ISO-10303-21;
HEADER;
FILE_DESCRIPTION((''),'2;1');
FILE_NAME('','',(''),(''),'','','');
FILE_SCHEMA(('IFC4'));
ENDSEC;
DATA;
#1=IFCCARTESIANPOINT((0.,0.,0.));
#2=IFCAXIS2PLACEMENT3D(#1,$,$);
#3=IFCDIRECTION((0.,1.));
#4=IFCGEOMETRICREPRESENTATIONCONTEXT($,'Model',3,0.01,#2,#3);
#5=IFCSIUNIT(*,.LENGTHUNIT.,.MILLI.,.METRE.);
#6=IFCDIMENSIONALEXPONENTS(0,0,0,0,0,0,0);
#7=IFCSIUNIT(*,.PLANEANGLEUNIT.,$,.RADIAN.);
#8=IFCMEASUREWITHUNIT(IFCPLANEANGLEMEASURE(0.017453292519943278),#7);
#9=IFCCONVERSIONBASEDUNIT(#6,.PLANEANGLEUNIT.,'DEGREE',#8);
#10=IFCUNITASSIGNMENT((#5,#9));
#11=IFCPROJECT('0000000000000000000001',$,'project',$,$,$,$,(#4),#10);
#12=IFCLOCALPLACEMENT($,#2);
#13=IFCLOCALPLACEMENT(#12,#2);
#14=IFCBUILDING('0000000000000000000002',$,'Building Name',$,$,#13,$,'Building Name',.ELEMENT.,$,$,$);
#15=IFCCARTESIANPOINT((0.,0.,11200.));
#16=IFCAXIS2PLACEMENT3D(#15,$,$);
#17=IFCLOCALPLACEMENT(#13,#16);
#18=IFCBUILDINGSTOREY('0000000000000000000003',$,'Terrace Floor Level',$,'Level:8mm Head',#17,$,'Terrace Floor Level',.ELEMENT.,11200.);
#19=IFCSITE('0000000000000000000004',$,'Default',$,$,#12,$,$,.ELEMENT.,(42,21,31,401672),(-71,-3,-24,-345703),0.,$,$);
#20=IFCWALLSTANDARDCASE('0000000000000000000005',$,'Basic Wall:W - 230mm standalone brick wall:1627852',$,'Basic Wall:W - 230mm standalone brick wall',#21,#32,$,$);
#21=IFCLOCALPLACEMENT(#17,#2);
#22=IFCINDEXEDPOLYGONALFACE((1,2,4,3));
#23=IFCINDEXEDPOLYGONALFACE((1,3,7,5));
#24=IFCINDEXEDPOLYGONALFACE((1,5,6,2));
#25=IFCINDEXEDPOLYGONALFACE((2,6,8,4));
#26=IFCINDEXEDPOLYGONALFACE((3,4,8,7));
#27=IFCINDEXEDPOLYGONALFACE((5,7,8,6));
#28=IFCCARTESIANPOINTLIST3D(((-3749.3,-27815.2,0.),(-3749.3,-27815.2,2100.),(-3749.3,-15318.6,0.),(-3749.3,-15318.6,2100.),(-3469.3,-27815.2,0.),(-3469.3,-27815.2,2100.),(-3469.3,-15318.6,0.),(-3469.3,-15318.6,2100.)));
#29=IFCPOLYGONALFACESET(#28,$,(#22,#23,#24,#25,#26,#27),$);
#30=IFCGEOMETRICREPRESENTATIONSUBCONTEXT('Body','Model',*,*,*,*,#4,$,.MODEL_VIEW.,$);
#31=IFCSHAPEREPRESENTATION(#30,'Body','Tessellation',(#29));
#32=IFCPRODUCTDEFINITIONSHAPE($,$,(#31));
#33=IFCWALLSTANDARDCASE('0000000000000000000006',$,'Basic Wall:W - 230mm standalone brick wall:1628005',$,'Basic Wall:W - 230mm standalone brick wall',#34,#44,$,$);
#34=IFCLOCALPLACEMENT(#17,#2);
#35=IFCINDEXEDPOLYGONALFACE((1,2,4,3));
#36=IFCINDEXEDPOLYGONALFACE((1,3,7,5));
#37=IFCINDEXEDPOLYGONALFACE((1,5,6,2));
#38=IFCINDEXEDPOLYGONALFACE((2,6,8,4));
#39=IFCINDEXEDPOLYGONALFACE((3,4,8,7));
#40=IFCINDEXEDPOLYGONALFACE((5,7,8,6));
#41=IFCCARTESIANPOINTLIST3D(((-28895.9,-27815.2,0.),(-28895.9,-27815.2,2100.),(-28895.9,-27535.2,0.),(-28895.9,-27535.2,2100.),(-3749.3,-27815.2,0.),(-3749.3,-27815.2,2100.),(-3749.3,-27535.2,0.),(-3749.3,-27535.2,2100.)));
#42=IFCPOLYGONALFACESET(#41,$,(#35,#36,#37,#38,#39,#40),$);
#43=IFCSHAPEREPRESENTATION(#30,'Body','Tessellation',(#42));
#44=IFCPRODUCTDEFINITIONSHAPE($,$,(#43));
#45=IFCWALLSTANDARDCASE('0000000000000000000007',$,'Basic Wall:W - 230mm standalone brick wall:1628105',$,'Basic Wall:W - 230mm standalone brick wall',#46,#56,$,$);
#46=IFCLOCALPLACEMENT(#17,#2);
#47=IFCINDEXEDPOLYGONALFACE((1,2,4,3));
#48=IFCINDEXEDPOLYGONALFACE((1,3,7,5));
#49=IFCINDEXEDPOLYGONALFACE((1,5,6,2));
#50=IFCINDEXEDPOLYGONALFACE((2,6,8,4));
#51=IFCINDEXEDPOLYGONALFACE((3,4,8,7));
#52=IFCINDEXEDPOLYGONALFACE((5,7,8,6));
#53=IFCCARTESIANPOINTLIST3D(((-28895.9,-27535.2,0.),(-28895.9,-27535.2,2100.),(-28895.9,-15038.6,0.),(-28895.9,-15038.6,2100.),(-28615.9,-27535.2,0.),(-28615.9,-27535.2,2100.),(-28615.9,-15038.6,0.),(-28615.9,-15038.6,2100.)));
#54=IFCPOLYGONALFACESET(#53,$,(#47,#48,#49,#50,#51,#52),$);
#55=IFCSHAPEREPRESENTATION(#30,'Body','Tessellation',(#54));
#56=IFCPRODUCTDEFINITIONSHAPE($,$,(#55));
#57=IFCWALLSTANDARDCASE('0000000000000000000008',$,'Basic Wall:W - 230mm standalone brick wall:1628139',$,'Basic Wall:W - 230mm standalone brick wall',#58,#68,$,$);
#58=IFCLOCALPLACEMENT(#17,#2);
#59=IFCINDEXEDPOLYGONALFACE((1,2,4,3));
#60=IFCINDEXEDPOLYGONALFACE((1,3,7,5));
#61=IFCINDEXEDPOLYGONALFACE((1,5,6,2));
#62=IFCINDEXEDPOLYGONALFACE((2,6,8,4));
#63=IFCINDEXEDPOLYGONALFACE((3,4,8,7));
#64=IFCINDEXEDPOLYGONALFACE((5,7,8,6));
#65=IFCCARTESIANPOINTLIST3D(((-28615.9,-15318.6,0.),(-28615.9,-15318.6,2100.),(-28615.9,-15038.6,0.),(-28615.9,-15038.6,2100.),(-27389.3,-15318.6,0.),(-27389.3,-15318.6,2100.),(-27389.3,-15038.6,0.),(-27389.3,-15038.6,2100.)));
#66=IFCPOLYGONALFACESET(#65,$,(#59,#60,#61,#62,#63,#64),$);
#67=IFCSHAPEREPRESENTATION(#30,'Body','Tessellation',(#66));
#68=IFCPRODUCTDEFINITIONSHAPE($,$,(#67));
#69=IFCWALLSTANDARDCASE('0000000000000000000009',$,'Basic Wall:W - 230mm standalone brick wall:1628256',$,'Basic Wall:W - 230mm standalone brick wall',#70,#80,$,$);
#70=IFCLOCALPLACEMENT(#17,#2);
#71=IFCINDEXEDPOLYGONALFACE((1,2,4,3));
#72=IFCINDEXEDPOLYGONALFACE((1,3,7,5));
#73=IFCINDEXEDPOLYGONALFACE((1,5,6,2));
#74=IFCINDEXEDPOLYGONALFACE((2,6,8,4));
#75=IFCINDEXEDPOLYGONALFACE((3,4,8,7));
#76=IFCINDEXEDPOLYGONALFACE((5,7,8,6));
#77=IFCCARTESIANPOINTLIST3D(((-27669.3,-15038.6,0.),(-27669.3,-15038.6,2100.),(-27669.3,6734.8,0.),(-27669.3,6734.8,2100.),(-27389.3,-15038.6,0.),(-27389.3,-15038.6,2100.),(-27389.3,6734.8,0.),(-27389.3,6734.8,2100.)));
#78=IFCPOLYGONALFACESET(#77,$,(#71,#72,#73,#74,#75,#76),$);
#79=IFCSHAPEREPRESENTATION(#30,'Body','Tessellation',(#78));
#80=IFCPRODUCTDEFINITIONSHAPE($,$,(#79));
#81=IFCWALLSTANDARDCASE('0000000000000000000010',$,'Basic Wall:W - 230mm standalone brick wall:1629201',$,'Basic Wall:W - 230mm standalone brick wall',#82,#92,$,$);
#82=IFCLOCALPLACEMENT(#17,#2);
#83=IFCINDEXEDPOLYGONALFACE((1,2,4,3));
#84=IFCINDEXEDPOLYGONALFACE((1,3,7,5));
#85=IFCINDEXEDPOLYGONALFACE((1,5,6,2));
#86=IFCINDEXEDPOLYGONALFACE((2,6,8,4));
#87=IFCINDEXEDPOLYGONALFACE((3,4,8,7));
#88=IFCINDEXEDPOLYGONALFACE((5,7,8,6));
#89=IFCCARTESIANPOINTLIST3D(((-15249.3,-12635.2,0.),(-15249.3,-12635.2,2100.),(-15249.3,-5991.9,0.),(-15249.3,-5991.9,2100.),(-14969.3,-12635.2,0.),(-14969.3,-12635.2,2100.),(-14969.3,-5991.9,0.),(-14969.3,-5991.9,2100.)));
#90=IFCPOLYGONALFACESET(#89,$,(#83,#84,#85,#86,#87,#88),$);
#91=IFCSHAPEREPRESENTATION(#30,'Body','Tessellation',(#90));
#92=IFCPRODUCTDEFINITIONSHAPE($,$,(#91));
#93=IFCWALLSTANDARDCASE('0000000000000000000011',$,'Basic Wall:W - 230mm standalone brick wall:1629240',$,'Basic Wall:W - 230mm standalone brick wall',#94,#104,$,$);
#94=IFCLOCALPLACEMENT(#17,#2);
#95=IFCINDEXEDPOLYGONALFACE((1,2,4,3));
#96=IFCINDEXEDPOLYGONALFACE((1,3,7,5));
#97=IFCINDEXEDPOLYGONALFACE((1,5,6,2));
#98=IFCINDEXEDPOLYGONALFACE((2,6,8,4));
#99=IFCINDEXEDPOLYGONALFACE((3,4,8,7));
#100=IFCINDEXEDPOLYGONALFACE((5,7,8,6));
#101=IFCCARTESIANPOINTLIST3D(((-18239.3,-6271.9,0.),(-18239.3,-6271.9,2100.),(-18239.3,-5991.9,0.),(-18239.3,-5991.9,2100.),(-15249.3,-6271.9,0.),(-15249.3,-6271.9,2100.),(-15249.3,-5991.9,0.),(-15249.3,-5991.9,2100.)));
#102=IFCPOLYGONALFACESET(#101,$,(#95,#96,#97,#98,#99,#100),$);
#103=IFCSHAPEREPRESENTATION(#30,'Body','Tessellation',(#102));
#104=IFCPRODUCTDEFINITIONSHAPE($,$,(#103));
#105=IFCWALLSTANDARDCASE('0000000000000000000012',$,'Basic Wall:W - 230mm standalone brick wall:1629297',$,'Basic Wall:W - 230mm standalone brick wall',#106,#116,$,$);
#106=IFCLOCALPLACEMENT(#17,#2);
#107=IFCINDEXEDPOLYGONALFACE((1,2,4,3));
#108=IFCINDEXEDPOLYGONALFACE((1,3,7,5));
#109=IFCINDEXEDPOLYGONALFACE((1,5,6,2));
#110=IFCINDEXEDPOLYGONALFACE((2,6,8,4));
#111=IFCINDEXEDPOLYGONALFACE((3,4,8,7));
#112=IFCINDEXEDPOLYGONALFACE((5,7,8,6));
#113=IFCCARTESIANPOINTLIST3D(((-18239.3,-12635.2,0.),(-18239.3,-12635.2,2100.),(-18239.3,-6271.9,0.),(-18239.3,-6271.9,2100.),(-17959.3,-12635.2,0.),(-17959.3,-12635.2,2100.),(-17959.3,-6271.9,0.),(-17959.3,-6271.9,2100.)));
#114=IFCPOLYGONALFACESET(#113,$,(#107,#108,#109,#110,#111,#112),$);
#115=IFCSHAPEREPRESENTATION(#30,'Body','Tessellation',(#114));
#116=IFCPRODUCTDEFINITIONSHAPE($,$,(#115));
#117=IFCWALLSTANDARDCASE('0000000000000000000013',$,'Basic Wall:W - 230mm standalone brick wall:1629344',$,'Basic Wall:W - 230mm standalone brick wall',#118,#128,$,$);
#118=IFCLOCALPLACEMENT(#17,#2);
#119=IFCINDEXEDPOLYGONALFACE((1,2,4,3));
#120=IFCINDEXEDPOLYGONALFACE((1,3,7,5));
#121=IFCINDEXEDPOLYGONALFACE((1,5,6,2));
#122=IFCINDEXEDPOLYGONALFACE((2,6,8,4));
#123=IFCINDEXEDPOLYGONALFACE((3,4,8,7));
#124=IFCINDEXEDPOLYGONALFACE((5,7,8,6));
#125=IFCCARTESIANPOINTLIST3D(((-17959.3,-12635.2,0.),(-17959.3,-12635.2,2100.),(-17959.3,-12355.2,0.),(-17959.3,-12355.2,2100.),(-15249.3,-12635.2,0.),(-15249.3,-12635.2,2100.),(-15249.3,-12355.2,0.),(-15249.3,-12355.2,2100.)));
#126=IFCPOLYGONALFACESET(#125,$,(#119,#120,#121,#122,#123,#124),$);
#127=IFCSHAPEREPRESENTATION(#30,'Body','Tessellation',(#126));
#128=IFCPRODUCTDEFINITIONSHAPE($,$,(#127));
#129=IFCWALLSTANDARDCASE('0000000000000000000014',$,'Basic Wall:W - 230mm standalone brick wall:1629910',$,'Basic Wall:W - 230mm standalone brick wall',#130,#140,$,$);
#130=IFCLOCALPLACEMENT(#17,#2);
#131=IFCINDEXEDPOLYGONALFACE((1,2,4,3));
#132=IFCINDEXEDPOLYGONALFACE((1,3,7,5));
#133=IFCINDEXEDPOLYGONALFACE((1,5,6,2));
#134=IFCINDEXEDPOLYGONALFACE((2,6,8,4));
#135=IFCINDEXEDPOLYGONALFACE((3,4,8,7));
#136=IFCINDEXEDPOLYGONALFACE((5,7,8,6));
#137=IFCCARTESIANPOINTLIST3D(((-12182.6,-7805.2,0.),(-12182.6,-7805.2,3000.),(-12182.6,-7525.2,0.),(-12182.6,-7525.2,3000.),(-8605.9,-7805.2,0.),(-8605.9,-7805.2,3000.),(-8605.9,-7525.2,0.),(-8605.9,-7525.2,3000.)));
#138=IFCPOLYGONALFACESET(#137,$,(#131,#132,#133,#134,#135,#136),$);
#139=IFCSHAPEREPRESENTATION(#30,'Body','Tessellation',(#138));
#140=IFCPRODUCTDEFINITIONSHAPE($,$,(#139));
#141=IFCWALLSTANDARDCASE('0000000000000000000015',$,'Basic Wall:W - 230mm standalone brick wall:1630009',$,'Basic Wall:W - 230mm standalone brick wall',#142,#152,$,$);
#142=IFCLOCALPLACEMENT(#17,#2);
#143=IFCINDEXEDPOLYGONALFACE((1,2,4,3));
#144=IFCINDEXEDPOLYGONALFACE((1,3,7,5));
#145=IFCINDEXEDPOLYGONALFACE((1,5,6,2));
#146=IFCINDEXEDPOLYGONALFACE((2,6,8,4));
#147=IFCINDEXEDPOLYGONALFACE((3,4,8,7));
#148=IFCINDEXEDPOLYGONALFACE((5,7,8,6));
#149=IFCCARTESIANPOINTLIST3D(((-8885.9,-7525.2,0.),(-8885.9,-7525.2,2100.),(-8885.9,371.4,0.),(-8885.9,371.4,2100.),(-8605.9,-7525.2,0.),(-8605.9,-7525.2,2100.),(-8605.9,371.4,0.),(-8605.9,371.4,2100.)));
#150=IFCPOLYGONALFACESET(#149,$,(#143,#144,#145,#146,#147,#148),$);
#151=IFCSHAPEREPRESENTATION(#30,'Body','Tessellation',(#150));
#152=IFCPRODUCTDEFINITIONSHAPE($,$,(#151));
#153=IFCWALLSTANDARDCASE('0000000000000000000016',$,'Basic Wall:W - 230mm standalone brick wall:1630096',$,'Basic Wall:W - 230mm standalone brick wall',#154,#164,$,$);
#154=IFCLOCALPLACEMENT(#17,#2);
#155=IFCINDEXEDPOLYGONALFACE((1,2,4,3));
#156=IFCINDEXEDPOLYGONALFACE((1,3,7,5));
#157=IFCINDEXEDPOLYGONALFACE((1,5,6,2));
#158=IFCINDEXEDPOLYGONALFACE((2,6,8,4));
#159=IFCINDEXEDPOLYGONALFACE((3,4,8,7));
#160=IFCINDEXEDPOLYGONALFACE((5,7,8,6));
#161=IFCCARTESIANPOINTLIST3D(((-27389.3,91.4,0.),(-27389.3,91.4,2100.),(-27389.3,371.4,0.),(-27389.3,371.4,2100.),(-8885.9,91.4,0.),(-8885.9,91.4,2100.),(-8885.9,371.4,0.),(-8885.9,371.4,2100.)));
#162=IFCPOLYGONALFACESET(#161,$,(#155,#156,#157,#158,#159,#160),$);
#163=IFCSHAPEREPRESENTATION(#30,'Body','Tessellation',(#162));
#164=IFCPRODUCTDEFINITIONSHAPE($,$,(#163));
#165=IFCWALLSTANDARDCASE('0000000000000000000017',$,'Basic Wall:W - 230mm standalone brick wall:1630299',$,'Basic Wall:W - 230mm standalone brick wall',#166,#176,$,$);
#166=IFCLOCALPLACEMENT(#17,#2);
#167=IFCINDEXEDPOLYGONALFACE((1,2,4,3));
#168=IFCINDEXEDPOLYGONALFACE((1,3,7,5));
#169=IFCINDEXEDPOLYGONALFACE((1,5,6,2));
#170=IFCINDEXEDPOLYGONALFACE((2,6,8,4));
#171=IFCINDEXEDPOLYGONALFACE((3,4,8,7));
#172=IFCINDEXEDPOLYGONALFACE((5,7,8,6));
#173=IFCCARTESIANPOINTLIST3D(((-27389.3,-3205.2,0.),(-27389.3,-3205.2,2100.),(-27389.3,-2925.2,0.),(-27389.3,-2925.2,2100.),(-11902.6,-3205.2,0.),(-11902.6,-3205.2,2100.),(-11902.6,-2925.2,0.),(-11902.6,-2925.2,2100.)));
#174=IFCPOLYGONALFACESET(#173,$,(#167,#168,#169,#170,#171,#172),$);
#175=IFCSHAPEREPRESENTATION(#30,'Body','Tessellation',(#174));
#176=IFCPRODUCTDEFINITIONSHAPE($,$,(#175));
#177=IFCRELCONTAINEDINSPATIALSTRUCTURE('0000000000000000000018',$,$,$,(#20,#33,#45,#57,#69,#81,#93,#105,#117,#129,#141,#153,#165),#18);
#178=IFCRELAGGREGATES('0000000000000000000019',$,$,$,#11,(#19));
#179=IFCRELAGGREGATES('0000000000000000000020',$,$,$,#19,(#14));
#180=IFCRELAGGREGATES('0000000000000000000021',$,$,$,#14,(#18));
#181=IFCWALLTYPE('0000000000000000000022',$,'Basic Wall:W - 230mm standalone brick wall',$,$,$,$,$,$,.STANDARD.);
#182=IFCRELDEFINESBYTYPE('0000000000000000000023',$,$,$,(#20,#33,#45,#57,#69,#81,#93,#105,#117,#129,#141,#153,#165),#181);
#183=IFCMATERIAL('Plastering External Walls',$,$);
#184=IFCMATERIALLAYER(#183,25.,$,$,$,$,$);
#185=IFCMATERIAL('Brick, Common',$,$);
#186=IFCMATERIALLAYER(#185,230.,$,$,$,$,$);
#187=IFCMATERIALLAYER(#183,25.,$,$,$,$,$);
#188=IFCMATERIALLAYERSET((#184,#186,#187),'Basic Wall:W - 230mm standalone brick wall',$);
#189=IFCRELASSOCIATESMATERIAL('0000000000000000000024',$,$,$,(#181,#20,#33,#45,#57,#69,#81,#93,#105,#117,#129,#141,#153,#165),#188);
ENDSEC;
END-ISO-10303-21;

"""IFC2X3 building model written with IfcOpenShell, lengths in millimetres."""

from ifc_helpers import new_model, entity, si_unit, converted_unit, direction, frame, frame_2d, origin, place, context, subcontext, project, spatial, rectangle, extrude, material, layer, layer_set, layer_usage, type_object, element, save


model = new_model("IFC2X3")

# Units and contexts
model_context = context("Model", 3, precision=0.01, world=origin(), true_north=direction((0.0, 1.0)))
body_context = subcontext(model_context, "Body", "Model", "MODEL_VIEW")
ifc_project = project(units=[si_unit("LENGTHUNIT", "METRE", prefix="MILLI"), converted_unit("PLANEANGLEUNIT", "DEGREE", entity("IfcPlaneAngleMeasure", 0.017453292519943278), si_unit("PLANEANGLEUNIT", "RADIAN"), dimensions=[0, 0, 0, 0, 0, 0, 0])], contexts=[model_context])

# Site, building, storey
site_placement = place(None, origin())
site = spatial("IfcSite", under=ifc_project, at=site_placement, Name="Default", CompositionType="ELEMENT", RefLatitude=(42, 21, 31, 401672), RefLongitude=(-71, -3, -24, -345703), RefElevation=0.0)
building_placement = place(site_placement, origin())
building = spatial("IfcBuilding", under=site, at=building_placement, Name="Building Name", LongName="Building Name", CompositionType="ELEMENT")
storey_placement = place(building_placement, frame((0.0, 0.0, 11200.0)))
storey = spatial("IfcBuildingStorey", under=building, at=storey_placement, Name="Terrace Floor Level", ObjectType="Level:8mm Head", LongName="Terrace Floor Level", CompositionType="ELEMENT", Elevation=11200.0)

# Walls
ifc_material_1 = material(Name="Plastering External Walls")
ifc_layer_1 = layer(ifc_material_1, 25.0)
ifc_material_2 = material(Name="Brick, Common")
ifc_layer_2 = layer(ifc_material_2, 230.0)
ifc_layer_3 = layer(ifc_material_1, 25.0)
ifc_layer_set_1 = layer_set([ifc_layer_1, ifc_layer_2, ifc_layer_3], Name="Basic Wall:W - 230mm standalone brick wall")
ifc_layer_usage_1 = layer_usage(ifc_layer_set_1, "AXIS2", "NEGATIVE", 140.0)
wall_type = type_object("IfcWallType", Name="Basic Wall:W - 230mm standalone brick wall", PredefinedType="STANDARD", material=ifc_layer_set_1)
wall_1_placement = place(storey_placement, frame((-3609.3, -15318.6, 0.0), z_axis=(0.0, 0.0, 1.0), x_axis=(0.0, -1.0, 0.0)))
element("IfcWallStandardCase", 1, at=wall_1_placement, inside=storey, type_object=wall_type, material=ifc_layer_usage_1, Name="Basic Wall:W - 230mm standalone brick wall:1627852", ObjectType="Basic Wall:W - 230mm standalone brick wall", context=body_context, shape_type="SweptSolid", body=[
    extrude(rectangle(XDim=12496.7, YDim=280.0, at=frame_2d((6248.3, 0.0), x_axis=(-1.0, 0.0))), origin(), (0.0, 0.0, 1.0), 2100.0),
])
ifc_layer_usage_2 = layer_usage(ifc_layer_set_1, "AXIS2", "NEGATIVE", 140.0)
wall_2_placement = place(storey_placement, frame((-3749.3, -27675.2, 0.0), z_axis=(0.0, 0.0, 1.0), x_axis=(-1.0, 0.0, 0.0)))
element("IfcWallStandardCase", 2, at=wall_2_placement, inside=storey, type_object=wall_type, material=ifc_layer_usage_2, Name="Basic Wall:W - 230mm standalone brick wall:1628005", ObjectType="Basic Wall:W - 230mm standalone brick wall", context=body_context, shape_type="SweptSolid", body=[
    extrude(rectangle(XDim=25146.7, YDim=280.0, at=frame_2d((12573.3, 0.0), x_axis=(-1.0, 0.0))), origin(), (0.0, 0.0, 1.0), 2100.0),
])
ifc_layer_usage_3 = layer_usage(ifc_layer_set_1, "AXIS2", "NEGATIVE", 140.0)
wall_3_placement = place(storey_placement, frame((-28755.9, -27535.2, 0.0), z_axis=(0.0, 0.0, 1.0), x_axis=(0.0, 1.0, 0.0)))
element("IfcWallStandardCase", 3, at=wall_3_placement, inside=storey, type_object=wall_type, material=ifc_layer_usage_3, Name="Basic Wall:W - 230mm standalone brick wall:1628105", ObjectType="Basic Wall:W - 230mm standalone brick wall", context=body_context, shape_type="SweptSolid", body=[
    extrude(rectangle(XDim=12496.7, YDim=280.0, at=frame_2d((6248.3, 0.0), x_axis=(-1.0, 0.0))), origin(), (0.0, 0.0, 1.0), 2100.0),
])
ifc_layer_usage_4 = layer_usage(ifc_layer_set_1, "AXIS2", "NEGATIVE", 140.0)
wall_4_placement = place(storey_placement, frame((-28615.9, -15178.6, 0.0)))
element("IfcWallStandardCase", 4, at=wall_4_placement, inside=storey, type_object=wall_type, material=ifc_layer_usage_4, Name="Basic Wall:W - 230mm standalone brick wall:1628139", ObjectType="Basic Wall:W - 230mm standalone brick wall", context=body_context, shape_type="SweptSolid", body=[
    extrude(rectangle(XDim=1226.7, YDim=280.0, at=frame_2d((613.3, 0.0), x_axis=(-1.0, 0.0))), origin(), (0.0, 0.0, 1.0), 2100.0),
])
ifc_layer_usage_5 = layer_usage(ifc_layer_set_1, "AXIS2", "NEGATIVE", 140.0)
wall_5_placement = place(storey_placement, frame((-27529.3, -15038.6, 0.0), z_axis=(0.0, 0.0, 1.0), x_axis=(0.0, 1.0, 0.0)))
element("IfcWallStandardCase", 5, at=wall_5_placement, inside=storey, type_object=wall_type, material=ifc_layer_usage_5, Name="Basic Wall:W - 230mm standalone brick wall:1628256", ObjectType="Basic Wall:W - 230mm standalone brick wall", context=body_context, shape_type="SweptSolid", body=[
    extrude(rectangle(XDim=21773.3, YDim=280.0, at=frame_2d((10886.7, 0.0), x_axis=(-1.0, 0.0))), origin(), (0.0, 0.0, 1.0), 2100.0),
])
ifc_layer_usage_6 = layer_usage(ifc_layer_set_1, "AXIS2", "NEGATIVE", 140.0)
wall_6_placement = place(storey_placement, frame((-15109.3, -12635.2, 0.0), z_axis=(0.0, 0.0, 1.0), x_axis=(0.0, 1.0, 0.0)))
element("IfcWallStandardCase", 6, at=wall_6_placement, inside=storey, type_object=wall_type, material=ifc_layer_usage_6, Name="Basic Wall:W - 230mm standalone brick wall:1629201", ObjectType="Basic Wall:W - 230mm standalone brick wall", context=body_context, shape_type="SweptSolid", body=[
    extrude(rectangle(XDim=6643.3, YDim=280.0, at=frame_2d((3321.7, 0.0), x_axis=(-1.0, 0.0))), origin(), (0.0, 0.0, 1.0), 2100.0),
])
ifc_layer_usage_7 = layer_usage(ifc_layer_set_1, "AXIS2", "NEGATIVE", 140.0)
wall_7_placement = place(storey_placement, frame((-15249.3, -6131.9, 0.0), z_axis=(0.0, 0.0, 1.0), x_axis=(-1.0, 0.0, 0.0)))
element("IfcWallStandardCase", 7, at=wall_7_placement, inside=storey, type_object=wall_type, material=ifc_layer_usage_7, Name="Basic Wall:W - 230mm standalone brick wall:1629240", ObjectType="Basic Wall:W - 230mm standalone brick wall", context=body_context, shape_type="SweptSolid", body=[
    extrude(rectangle(XDim=2990.0, YDim=280.0, at=frame_2d((1495.0, 0.0), x_axis=(-1.0, 0.0))), origin(), (0.0, 0.0, 1.0), 2100.0),
])
ifc_layer_usage_8 = layer_usage(ifc_layer_set_1, "AXIS2", "NEGATIVE", 140.0)
wall_8_placement = place(storey_placement, frame((-18099.3, -6271.9, 0.0), z_axis=(0.0, 0.0, 1.0), x_axis=(0.0, -1.0, 0.0)))
element("IfcWallStandardCase", 8, at=wall_8_placement, inside=storey, type_object=wall_type, material=ifc_layer_usage_8, Name="Basic Wall:W - 230mm standalone brick wall:1629297", ObjectType="Basic Wall:W - 230mm standalone brick wall", context=body_context, shape_type="SweptSolid", body=[
    extrude(rectangle(XDim=6363.3, YDim=280.0, at=frame_2d((3181.7, 0.0), x_axis=(-1.0, 0.0))), origin(), (0.0, 0.0, 1.0), 2100.0),
])
ifc_layer_usage_9 = layer_usage(ifc_layer_set_1, "AXIS2", "NEGATIVE", 140.0)
wall_9_placement = place(storey_placement, frame((-17959.3, -12495.2, 0.0)))
element("IfcWallStandardCase", 9, at=wall_9_placement, inside=storey, type_object=wall_type, material=ifc_layer_usage_9, Name="Basic Wall:W - 230mm standalone brick wall:1629344", ObjectType="Basic Wall:W - 230mm standalone brick wall", context=body_context, shape_type="SweptSolid", body=[
    extrude(rectangle(XDim=2710.0, YDim=280.0, at=frame_2d((1355.0, 0.0), x_axis=(-1.0, 0.0))), origin(), (0.0, 0.0, 1.0), 2100.0),
])
ifc_layer_usage_10 = layer_usage(ifc_layer_set_1, "AXIS2", "NEGATIVE", 140.0)
wall_10_placement = place(storey_placement, frame((-12182.6, -7665.2, 0.0)))
element("IfcWallStandardCase", 10, at=wall_10_placement, inside=storey, type_object=wall_type, material=ifc_layer_usage_10, Name="Basic Wall:W - 230mm standalone brick wall:1629910", ObjectType="Basic Wall:W - 230mm standalone brick wall", context=body_context, shape_type="SweptSolid", body=[
    extrude(rectangle(XDim=3576.7, YDim=280.0, at=frame_2d((1788.3, 0.0), x_axis=(-1.0, 0.0))), origin(), (0.0, 0.0, 1.0), 3000.0),
])
ifc_layer_usage_11 = layer_usage(ifc_layer_set_1, "AXIS2", "NEGATIVE", 140.0)
wall_11_placement = place(storey_placement, frame((-8745.9, -7525.2, 0.0), z_axis=(0.0, 0.0, 1.0), x_axis=(0.0, 1.0, 0.0)))
element("IfcWallStandardCase", 11, at=wall_11_placement, inside=storey, type_object=wall_type, material=ifc_layer_usage_11, Name="Basic Wall:W - 230mm standalone brick wall:1630009", ObjectType="Basic Wall:W - 230mm standalone brick wall", context=body_context, shape_type="SweptSolid", body=[
    extrude(rectangle(XDim=7896.7, YDim=280.0, at=frame_2d((3948.3, 0.0), x_axis=(-1.0, 0.0))), origin(), (0.0, 0.0, 1.0), 2100.0),
])
ifc_layer_usage_12 = layer_usage(ifc_layer_set_1, "AXIS2", "NEGATIVE", 140.0)
wall_12_placement = place(storey_placement, frame((-8885.9, 231.4, 0.0), z_axis=(0.0, 0.0, 1.0), x_axis=(-1.0, 0.0, 0.0)))
element("IfcWallStandardCase", 12, at=wall_12_placement, inside=storey, type_object=wall_type, material=ifc_layer_usage_12, Name="Basic Wall:W - 230mm standalone brick wall:1630096", ObjectType="Basic Wall:W - 230mm standalone brick wall", context=body_context, shape_type="SweptSolid", body=[
    extrude(rectangle(XDim=18503.3, YDim=280.0, at=frame_2d((9251.7, 0.0), x_axis=(-1.0, 0.0))), origin(), (0.0, 0.0, 1.0), 2100.0),
])
ifc_layer_usage_13 = layer_usage(ifc_layer_set_1, "AXIS2", "NEGATIVE", 140.0)
wall_13_placement = place(storey_placement, frame((-27389.3, -3065.2, 0.0)))
element("IfcWallStandardCase", 13, at=wall_13_placement, inside=storey, type_object=wall_type, material=ifc_layer_usage_13, Name="Basic Wall:W - 230mm standalone brick wall:1630299", ObjectType="Basic Wall:W - 230mm standalone brick wall", context=body_context, shape_type="SweptSolid", body=[
    extrude(rectangle(XDim=15486.7, YDim=280.0, at=frame_2d((7743.3, 0.0), x_axis=(-1.0, 0.0))), origin(), (0.0, 0.0, 1.0), 2100.0),
])

save(model, "model.ifc")
